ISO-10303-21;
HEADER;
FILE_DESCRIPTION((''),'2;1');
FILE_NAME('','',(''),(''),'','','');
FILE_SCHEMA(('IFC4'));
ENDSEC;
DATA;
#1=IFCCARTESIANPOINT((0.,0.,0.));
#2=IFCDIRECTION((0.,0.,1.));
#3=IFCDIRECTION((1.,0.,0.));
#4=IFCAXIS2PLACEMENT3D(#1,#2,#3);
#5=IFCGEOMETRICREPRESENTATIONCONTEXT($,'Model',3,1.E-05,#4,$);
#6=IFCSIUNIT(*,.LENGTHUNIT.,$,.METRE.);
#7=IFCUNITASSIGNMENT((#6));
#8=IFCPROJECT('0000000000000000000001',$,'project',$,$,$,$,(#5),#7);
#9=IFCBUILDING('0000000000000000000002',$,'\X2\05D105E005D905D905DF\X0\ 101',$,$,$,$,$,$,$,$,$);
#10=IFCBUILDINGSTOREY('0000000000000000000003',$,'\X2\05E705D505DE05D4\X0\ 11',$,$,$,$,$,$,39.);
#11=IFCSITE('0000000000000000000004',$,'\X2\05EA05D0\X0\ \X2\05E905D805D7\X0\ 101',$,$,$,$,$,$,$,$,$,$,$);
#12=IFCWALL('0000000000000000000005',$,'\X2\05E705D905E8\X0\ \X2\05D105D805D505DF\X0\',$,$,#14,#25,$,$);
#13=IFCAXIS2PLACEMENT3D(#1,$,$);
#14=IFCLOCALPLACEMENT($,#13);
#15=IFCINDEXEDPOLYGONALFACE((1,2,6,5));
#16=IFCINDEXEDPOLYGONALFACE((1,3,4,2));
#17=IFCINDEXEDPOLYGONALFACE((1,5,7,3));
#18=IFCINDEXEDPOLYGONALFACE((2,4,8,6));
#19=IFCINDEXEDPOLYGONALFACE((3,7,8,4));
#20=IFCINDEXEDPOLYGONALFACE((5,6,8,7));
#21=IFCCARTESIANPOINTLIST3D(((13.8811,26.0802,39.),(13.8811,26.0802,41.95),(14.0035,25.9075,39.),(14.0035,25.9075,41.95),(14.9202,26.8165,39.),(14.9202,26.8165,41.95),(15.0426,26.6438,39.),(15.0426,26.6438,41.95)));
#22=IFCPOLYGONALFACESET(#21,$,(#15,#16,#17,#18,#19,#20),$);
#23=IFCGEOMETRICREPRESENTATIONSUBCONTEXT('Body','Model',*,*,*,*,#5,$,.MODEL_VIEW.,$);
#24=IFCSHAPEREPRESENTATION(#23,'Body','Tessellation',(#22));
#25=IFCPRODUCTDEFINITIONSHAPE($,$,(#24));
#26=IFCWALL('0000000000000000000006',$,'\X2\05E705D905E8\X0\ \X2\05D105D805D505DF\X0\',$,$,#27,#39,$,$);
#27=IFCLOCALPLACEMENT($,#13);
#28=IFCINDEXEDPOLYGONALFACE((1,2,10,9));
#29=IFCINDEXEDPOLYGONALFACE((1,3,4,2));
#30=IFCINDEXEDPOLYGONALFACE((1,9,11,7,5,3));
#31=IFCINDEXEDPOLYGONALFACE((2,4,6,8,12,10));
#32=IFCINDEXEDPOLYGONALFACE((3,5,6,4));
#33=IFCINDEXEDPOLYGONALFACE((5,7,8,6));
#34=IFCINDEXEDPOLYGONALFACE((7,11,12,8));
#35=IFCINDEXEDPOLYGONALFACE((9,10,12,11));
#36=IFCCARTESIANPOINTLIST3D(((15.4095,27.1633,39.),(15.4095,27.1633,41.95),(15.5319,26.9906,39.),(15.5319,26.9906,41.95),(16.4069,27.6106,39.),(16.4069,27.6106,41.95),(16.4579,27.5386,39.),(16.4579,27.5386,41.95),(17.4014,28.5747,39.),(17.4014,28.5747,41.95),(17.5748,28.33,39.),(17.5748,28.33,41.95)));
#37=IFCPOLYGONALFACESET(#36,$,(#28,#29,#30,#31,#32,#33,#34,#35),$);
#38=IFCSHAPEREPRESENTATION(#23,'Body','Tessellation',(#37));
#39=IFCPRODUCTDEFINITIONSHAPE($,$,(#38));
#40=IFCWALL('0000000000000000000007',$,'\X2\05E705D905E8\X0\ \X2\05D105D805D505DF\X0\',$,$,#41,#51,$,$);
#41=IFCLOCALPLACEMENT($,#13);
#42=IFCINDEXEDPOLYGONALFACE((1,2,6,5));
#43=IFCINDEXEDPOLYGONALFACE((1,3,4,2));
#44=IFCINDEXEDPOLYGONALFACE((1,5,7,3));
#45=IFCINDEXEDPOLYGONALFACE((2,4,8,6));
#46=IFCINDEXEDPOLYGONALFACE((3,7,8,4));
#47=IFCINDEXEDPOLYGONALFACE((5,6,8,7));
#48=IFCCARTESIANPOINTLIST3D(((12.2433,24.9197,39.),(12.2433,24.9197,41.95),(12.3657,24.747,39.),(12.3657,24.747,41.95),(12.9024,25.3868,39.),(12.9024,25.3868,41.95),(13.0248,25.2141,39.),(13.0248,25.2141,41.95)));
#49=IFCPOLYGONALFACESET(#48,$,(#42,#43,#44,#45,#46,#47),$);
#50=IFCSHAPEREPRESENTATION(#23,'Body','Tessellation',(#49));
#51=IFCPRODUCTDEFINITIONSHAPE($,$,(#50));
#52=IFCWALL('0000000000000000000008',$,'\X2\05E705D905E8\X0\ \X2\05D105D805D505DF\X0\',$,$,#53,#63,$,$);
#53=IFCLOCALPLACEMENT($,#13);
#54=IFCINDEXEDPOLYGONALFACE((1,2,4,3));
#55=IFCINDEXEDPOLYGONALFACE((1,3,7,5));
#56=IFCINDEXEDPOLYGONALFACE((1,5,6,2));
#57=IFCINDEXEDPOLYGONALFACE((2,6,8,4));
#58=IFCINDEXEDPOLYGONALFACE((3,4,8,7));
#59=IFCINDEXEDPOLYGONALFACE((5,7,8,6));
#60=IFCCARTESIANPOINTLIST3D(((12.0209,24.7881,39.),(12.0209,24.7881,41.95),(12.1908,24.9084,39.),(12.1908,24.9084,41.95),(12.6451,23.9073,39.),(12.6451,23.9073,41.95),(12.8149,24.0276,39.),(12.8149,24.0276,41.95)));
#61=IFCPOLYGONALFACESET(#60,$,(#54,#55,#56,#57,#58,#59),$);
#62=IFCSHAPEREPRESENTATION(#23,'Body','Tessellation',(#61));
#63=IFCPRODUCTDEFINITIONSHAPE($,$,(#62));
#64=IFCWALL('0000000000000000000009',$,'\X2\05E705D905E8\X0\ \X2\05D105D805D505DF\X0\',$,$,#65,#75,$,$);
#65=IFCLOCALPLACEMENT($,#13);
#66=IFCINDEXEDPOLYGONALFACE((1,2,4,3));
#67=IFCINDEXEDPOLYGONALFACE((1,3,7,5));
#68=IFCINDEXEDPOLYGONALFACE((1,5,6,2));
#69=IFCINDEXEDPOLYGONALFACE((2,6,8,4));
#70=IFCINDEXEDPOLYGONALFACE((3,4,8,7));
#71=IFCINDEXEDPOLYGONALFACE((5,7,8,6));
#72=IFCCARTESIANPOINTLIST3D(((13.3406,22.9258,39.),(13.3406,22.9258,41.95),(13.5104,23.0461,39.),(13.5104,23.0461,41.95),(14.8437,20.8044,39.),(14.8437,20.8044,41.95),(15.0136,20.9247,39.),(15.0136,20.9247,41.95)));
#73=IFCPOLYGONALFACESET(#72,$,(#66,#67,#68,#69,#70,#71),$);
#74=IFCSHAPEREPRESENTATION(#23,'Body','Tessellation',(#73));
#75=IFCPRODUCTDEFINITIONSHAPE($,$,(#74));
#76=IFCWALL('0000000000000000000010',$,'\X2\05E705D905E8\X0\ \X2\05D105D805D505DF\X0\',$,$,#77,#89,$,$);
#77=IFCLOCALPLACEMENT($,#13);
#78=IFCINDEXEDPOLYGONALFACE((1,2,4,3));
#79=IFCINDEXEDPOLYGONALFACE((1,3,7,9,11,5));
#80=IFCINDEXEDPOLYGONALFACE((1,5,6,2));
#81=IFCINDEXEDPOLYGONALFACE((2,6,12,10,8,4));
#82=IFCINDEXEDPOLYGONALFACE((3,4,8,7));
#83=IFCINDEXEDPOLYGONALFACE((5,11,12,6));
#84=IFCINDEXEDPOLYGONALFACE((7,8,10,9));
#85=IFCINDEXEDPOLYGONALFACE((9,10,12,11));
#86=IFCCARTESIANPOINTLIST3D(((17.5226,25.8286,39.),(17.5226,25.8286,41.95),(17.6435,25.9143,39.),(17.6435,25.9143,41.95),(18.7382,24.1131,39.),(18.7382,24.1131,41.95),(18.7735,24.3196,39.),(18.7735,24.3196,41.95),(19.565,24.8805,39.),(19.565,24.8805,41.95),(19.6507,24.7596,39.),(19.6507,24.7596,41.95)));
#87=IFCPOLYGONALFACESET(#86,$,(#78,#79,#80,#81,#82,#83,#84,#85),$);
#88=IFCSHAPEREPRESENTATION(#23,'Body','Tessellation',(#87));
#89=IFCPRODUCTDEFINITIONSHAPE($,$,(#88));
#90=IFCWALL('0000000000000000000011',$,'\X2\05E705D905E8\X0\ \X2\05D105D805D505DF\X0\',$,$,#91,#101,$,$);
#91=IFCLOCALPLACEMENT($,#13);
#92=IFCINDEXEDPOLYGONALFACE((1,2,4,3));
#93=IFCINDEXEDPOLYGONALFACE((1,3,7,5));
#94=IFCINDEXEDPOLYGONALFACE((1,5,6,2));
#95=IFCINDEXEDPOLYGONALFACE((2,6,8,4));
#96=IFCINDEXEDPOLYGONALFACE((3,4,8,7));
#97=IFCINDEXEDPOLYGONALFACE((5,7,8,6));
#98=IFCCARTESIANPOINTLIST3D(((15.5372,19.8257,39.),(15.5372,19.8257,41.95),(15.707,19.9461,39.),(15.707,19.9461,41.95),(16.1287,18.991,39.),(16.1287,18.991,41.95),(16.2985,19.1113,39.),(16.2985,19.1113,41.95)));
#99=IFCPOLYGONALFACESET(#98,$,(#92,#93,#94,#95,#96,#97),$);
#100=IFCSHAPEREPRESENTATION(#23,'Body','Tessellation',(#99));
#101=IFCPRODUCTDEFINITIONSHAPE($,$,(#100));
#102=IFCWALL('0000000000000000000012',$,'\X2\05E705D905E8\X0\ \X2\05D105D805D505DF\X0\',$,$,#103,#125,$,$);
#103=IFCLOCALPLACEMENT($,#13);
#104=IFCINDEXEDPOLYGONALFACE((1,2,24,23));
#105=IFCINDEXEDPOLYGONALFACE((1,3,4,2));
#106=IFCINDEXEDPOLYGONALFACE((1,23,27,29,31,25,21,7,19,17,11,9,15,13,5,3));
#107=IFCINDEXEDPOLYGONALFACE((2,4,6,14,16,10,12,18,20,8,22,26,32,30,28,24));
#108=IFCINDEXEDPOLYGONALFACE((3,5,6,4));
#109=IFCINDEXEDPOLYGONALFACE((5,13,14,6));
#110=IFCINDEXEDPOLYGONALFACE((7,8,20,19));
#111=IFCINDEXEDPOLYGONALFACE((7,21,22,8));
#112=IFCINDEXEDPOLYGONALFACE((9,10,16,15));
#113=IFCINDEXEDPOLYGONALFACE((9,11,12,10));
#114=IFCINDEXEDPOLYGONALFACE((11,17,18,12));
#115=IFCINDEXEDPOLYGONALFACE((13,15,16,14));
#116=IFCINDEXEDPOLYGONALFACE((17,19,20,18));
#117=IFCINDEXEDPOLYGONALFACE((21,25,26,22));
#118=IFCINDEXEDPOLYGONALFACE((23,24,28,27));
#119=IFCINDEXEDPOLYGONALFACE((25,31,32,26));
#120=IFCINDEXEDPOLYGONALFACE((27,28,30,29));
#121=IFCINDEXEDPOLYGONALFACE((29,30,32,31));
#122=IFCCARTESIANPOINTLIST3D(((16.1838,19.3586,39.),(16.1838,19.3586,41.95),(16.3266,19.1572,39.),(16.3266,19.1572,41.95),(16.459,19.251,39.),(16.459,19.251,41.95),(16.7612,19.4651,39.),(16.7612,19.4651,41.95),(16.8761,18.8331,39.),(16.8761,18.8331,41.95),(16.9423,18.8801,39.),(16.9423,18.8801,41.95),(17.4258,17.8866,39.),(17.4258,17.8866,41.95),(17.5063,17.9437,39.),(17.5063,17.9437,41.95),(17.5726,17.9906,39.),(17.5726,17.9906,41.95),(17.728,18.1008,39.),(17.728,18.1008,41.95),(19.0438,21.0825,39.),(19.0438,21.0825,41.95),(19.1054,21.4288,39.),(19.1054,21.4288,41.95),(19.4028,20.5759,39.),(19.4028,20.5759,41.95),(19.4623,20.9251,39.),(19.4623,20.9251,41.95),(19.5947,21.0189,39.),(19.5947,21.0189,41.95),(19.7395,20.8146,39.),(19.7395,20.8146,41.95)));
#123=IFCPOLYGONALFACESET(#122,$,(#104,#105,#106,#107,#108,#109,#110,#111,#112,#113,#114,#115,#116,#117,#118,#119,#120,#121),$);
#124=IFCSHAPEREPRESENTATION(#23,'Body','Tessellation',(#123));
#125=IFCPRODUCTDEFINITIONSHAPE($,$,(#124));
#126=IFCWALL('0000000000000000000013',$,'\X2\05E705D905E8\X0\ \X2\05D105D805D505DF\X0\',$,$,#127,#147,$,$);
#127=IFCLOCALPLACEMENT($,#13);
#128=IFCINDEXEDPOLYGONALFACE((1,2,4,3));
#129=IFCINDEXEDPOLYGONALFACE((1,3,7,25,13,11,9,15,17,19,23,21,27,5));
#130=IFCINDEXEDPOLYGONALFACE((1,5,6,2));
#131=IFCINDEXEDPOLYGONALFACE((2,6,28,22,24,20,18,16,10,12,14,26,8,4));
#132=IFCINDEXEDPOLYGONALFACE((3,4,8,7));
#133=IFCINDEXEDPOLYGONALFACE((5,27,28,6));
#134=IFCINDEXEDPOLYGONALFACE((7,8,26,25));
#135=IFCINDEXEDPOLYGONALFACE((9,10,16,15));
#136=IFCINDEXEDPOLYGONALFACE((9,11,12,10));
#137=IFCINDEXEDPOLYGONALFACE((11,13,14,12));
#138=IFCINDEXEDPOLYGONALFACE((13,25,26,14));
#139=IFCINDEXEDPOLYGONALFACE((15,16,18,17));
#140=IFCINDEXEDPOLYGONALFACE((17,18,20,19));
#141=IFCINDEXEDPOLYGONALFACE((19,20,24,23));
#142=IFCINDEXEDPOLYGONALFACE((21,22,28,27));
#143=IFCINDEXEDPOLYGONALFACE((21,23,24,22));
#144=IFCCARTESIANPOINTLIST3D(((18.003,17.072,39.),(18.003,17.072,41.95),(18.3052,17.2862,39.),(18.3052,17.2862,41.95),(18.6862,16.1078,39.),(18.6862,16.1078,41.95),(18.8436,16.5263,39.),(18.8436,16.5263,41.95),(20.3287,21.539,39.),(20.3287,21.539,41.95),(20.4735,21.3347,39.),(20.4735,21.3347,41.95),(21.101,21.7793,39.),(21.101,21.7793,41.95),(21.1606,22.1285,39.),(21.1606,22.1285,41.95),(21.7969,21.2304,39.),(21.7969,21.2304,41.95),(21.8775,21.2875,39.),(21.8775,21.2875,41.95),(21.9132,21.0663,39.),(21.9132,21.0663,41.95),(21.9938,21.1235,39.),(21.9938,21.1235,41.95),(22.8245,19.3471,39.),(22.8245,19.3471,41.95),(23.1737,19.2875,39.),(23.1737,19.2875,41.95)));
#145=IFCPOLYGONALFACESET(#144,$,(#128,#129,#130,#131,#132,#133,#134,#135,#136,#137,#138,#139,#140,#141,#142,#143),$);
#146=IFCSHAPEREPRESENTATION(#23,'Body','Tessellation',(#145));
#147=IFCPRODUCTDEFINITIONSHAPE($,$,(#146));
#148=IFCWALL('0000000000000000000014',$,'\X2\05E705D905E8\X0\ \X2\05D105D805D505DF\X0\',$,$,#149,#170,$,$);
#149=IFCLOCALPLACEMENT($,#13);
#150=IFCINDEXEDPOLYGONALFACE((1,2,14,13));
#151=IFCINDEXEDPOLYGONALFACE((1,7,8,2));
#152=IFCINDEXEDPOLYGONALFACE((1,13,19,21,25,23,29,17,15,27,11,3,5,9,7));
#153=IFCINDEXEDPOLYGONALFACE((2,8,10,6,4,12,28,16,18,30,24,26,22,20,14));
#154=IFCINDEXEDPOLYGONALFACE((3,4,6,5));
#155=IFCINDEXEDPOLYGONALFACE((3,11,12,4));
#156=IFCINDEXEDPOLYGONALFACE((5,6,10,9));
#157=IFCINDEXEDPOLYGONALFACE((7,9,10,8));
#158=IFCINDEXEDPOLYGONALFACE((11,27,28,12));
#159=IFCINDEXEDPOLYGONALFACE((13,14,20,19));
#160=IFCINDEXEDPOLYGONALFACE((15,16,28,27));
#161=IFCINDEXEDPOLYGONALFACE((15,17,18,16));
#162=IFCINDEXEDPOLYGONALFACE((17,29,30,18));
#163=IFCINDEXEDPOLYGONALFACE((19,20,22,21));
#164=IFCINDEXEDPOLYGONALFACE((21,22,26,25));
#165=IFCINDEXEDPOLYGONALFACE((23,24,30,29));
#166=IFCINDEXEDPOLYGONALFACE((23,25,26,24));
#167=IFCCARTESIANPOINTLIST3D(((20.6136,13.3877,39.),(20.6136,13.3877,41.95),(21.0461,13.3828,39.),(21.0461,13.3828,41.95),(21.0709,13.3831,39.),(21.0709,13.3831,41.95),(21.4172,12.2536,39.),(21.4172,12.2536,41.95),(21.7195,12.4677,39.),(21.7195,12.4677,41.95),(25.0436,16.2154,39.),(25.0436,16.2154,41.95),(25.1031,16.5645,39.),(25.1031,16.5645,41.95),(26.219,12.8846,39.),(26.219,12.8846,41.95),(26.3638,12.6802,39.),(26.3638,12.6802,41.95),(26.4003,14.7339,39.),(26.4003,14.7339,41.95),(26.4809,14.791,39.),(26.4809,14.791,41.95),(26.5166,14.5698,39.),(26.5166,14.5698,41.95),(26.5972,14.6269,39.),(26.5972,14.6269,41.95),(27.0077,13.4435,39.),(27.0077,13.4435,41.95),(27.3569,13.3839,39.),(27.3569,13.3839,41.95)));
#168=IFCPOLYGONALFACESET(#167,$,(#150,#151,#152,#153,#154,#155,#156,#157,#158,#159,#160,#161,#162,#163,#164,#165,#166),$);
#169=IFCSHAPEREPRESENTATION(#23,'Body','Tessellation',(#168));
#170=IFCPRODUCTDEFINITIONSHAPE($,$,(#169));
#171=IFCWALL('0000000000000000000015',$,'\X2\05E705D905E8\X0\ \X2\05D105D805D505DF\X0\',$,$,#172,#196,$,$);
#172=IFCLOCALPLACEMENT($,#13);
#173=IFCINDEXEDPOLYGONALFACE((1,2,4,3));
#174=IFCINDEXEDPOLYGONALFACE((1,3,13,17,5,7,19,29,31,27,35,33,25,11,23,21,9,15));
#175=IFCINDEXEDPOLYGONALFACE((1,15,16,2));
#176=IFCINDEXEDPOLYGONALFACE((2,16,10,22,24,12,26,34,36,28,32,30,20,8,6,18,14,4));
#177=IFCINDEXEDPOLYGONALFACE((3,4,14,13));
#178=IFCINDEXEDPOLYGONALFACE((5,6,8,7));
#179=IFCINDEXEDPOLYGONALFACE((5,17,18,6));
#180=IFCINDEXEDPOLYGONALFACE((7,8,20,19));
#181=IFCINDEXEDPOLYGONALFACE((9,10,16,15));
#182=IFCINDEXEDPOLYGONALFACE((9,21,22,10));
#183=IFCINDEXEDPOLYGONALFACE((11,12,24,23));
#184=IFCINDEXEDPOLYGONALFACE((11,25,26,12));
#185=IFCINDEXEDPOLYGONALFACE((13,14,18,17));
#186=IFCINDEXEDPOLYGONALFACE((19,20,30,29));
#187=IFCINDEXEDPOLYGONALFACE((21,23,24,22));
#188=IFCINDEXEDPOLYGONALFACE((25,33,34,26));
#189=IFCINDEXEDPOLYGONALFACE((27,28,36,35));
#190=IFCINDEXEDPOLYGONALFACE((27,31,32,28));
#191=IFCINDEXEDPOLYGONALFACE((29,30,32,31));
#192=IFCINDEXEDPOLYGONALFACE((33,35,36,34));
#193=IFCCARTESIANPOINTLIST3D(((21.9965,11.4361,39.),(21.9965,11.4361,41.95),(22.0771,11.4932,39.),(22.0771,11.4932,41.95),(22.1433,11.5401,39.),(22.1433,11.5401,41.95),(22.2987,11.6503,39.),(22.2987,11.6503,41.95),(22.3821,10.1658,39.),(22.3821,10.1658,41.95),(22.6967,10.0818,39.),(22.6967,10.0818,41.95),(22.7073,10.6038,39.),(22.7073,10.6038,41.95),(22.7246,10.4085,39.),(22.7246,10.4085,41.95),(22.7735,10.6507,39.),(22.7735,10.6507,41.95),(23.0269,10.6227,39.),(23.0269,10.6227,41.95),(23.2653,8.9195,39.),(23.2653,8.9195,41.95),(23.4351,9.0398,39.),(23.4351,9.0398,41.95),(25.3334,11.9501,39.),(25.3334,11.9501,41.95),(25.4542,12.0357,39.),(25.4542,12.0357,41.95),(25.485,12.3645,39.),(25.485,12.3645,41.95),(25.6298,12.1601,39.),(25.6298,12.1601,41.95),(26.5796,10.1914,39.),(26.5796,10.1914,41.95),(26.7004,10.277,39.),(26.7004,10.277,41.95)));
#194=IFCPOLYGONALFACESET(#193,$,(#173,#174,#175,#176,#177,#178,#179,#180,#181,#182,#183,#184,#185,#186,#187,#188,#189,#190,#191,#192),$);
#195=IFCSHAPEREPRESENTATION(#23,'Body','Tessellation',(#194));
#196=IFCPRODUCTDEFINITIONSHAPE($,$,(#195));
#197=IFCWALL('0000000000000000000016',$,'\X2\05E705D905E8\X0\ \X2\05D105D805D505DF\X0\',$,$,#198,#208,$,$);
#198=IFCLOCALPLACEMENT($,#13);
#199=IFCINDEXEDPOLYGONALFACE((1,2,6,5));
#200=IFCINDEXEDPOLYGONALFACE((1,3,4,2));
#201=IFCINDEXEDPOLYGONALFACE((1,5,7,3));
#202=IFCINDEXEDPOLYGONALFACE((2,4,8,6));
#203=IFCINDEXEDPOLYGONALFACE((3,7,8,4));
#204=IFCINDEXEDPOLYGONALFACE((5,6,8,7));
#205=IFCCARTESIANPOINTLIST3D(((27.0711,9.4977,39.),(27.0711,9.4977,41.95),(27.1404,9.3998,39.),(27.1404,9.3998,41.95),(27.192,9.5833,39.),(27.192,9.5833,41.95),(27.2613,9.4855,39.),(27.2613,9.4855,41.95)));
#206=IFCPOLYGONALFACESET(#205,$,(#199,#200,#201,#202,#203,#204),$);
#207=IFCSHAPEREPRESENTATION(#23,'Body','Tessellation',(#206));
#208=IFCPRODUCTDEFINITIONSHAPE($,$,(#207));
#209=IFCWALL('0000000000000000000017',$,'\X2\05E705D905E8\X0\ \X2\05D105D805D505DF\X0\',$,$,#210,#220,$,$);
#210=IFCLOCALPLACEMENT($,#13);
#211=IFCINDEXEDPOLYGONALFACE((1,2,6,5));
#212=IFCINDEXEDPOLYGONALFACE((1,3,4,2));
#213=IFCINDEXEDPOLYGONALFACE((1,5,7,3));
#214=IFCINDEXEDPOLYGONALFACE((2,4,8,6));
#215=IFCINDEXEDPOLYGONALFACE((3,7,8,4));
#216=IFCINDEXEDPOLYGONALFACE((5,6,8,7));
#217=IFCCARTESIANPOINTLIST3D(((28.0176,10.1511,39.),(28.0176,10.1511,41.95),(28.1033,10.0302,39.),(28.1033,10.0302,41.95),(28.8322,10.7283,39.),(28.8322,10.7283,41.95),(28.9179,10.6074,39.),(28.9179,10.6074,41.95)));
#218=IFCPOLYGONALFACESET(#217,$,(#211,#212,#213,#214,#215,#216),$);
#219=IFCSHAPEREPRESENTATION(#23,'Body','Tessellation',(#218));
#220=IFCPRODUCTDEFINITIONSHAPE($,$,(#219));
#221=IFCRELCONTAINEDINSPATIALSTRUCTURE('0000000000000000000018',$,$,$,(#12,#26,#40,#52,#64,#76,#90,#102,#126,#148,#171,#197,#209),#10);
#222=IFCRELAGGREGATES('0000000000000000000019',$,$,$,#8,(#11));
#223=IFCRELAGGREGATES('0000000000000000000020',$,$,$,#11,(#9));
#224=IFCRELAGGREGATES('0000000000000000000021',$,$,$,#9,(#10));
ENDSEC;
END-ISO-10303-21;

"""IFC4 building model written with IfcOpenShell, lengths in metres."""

from ifc_helpers import new_model, si_unit, frame, origin_with_axes, context, subcontext, project, spatial, polyline, outline, extrude, element, save


model = new_model("IFC4")

# Units and contexts
model_context = context("Model", 3, precision=1e-05, world=origin_with_axes())
body_context = subcontext(model_context, "Body", "Model", "MODEL_VIEW")
ifc_project = project(units=[si_unit("LENGTHUNIT", "METRE")], contexts=[model_context])

# Site, building, storey
site = spatial("IfcSite", under=ifc_project, Name="תא שטח 101")
building = spatial("IfcBuilding", under=site, Name="בניין 101")
storey = spatial("IfcBuildingStorey", under=building, Name="קומה 11", Elevation=39.0)

# Walls
element("IfcWall", 1, inside=storey, Name="קיר בטון", context=body_context, shape_type="SweptSolid", body=[
    extrude(outline(polyline([(14.9202, 26.8165), (13.8811, 26.0802), (14.0035, 25.9075), (15.0426, 26.6438), (14.9202, 26.8165)])), frame((0.0, 0.0, 39.0)), (0.0, 0.0, 1.0), 2.95),
])
element("IfcWall", 2, inside=storey, Name="קיר בטון", context=body_context, shape_type="SweptSolid", body=[
    extrude(outline(polyline([(16.4579, 27.5386), (17.5748, 28.33), (17.4014, 28.5747), (15.4095, 27.1633), (15.5319, 26.9906), (16.4069, 27.6106), (16.4579, 27.5386)])), frame((0.0, 0.0, 39.0)), (0.0, 0.0, 1.0), 2.95),
])
element("IfcWall", 3, inside=storey, Name="קיר בטון", context=body_context, shape_type="SweptSolid", body=[
    extrude(outline(polyline([(12.9024, 25.3868), (12.2433, 24.9197), (12.3657, 24.747), (13.0248, 25.2141), (12.9024, 25.3868)])), frame((0.0, 0.0, 39.0)), (0.0, 0.0, 1.0), 2.95),
])
element("IfcWall", 4, inside=storey, Name="קיר בטון", context=body_context, shape_type="SweptSolid", body=[
    extrude(outline(polyline([(12.1908, 24.9084), (12.0209, 24.7881), (12.6451, 23.9073), (12.8149, 24.0276), (12.1908, 24.9084)])), frame((0.0, 0.0, 39.0)), (0.0, 0.0, 1.0), 2.95),
])
element("IfcWall", 5, inside=storey, Name="קיר בטון", context=body_context, shape_type="SweptSolid", body=[
    extrude(outline(polyline([(14.8437, 20.8044), (15.0136, 20.9247), (13.5104, 23.0461), (13.3406, 22.9258), (14.8437, 20.8044)])), frame((0.0, 0.0, 39.0)), (0.0, 0.0, 1.0), 2.95),
])
element("IfcWall", 6, inside=storey, Name="קיר בטון", context=body_context, shape_type="SweptSolid", body=[
    extrude(outline(polyline([(18.7382, 24.1131), (19.6507, 24.7596), (19.565, 24.8805), (18.7735, 24.3196), (17.6435, 25.9143), (17.5226, 25.8286), (18.7382, 24.1131)])), frame((0.0, 0.0, 39.0)), (0.0, 0.0, 1.0), 2.95),
])
element("IfcWall", 7, inside=storey, Name="קיר בטון", context=body_context, shape_type="SweptSolid", body=[
    extrude(outline(polyline([(15.5372, 19.8257), (16.1287, 18.991), (16.2985, 19.1113), (15.707, 19.9461), (15.5372, 19.8257)])), frame((0.0, 0.0, 39.0)), (0.0, 0.0, 1.0), 2.95),
])
element("IfcWall", 8, inside=storey, Name="קיר בטון", context=body_context, shape_type="SweptSolid", body=[
    extrude(outline(polyline([(19.4028, 20.5759), (19.7395, 20.8146), (19.5947, 21.0189), (19.4623, 20.9251), (19.1054, 21.4288), (16.1838, 19.3586), (16.3266, 19.1572), (16.459, 19.251), (17.4258, 17.8866), (17.5063, 17.9437), (16.8761, 18.8331), (16.9423, 18.8801), (17.5726, 17.9906), (17.728, 18.1008), (16.7612, 19.4651), (19.0438, 21.0825), (19.4028, 20.5759)])), frame((0.0, 0.0, 39.0)), (0.0, 0.0, 1.0), 2.95),
])
element("IfcWall", 9, inside=storey, Name="קיר בטון", context=body_context, shape_type="SweptSolid", body=[
    extrude(outline(polyline([(21.101, 21.7793), (22.8245, 19.3471), (18.8436, 16.5263), (18.3052, 17.2862), (18.003, 17.072), (18.6862, 16.1078), (23.1737, 19.2875), (21.9132, 21.0663), (21.9938, 21.1235), (21.8775, 21.2875), (21.7969, 21.2304), (21.8846, 21.1066), (21.1606, 22.1285), (20.3287, 21.539), (20.4735, 21.3347), (21.101, 21.7793)])), frame((0.0, 0.0, 39.0)), (0.0, 0.0, 1.0), 2.95),
])
element("IfcWall", 10, inside=storey, Name="קיר בטון", context=body_context, shape_type="SweptSolid", body=[
    extrude(outline(polyline([(27.0077, 13.4435), (26.219, 12.8846), (26.3638, 12.6802), (27.3569, 13.3839), (26.5166, 14.5698), (26.5972, 14.6269), (26.4809, 14.791), (26.4003, 14.7339), (25.1031, 16.5645), (20.6136, 13.3877), (21.4172, 12.2536), (21.7195, 12.4677), (21.0709, 13.3831), (20.9593, 13.3819), (21.0455, 13.3823), (25.0436, 16.2154), (27.0077, 13.4435)])), frame((0.0, 0.0, 39.0)), (0.0, 0.0, 1.0), 2.95),
])
element("IfcWall", 11, inside=storey, Name="קיר בטון", context=body_context, shape_type="SweptSolid", body=[
    extrude(outline(polyline([(21.9965, 11.4361), (22.7246, 10.4085), (22.3821, 10.1658), (23.2653, 8.9195), (23.4351, 9.0398), (22.6967, 10.0818), (25.3334, 11.9501), (26.5796, 10.1914), (26.7004, 10.277), (25.4542, 12.0357), (25.6298, 12.1601), (25.485, 12.3645), (23.0269, 10.6227), (22.2987, 11.6503), (22.1433, 11.5401), (22.7735, 10.6507), (22.7073, 10.6038), (22.0771, 11.4932), (21.9965, 11.4361)])), frame((0.0, 0.0, 39.0)), (0.0, 0.0, 1.0), 2.95),
])
element("IfcWall", 12, inside=storey, Name="קיר בטון", context=body_context, shape_type="SweptSolid", body=[
    extrude(outline(polyline([(27.0711, 9.4977), (27.1404, 9.3998), (27.2613, 9.4855), (27.192, 9.5833), (27.0711, 9.4977)])), frame((0.0, 0.0, 39.0)), (0.0, 0.0, 1.0), 2.95),
])
element("IfcWall", 13, inside=storey, Name="קיר בטון", context=body_context, shape_type="SweptSolid", body=[
    extrude(outline(polyline([(28.0176, 10.1511), (28.1033, 10.0302), (28.9179, 10.6074), (28.8322, 10.7283), (28.0176, 10.1511)])), frame((0.0, 0.0, 39.0)), (0.0, 0.0, 1.0), 2.95),
])

save(model, "model.ifc")
